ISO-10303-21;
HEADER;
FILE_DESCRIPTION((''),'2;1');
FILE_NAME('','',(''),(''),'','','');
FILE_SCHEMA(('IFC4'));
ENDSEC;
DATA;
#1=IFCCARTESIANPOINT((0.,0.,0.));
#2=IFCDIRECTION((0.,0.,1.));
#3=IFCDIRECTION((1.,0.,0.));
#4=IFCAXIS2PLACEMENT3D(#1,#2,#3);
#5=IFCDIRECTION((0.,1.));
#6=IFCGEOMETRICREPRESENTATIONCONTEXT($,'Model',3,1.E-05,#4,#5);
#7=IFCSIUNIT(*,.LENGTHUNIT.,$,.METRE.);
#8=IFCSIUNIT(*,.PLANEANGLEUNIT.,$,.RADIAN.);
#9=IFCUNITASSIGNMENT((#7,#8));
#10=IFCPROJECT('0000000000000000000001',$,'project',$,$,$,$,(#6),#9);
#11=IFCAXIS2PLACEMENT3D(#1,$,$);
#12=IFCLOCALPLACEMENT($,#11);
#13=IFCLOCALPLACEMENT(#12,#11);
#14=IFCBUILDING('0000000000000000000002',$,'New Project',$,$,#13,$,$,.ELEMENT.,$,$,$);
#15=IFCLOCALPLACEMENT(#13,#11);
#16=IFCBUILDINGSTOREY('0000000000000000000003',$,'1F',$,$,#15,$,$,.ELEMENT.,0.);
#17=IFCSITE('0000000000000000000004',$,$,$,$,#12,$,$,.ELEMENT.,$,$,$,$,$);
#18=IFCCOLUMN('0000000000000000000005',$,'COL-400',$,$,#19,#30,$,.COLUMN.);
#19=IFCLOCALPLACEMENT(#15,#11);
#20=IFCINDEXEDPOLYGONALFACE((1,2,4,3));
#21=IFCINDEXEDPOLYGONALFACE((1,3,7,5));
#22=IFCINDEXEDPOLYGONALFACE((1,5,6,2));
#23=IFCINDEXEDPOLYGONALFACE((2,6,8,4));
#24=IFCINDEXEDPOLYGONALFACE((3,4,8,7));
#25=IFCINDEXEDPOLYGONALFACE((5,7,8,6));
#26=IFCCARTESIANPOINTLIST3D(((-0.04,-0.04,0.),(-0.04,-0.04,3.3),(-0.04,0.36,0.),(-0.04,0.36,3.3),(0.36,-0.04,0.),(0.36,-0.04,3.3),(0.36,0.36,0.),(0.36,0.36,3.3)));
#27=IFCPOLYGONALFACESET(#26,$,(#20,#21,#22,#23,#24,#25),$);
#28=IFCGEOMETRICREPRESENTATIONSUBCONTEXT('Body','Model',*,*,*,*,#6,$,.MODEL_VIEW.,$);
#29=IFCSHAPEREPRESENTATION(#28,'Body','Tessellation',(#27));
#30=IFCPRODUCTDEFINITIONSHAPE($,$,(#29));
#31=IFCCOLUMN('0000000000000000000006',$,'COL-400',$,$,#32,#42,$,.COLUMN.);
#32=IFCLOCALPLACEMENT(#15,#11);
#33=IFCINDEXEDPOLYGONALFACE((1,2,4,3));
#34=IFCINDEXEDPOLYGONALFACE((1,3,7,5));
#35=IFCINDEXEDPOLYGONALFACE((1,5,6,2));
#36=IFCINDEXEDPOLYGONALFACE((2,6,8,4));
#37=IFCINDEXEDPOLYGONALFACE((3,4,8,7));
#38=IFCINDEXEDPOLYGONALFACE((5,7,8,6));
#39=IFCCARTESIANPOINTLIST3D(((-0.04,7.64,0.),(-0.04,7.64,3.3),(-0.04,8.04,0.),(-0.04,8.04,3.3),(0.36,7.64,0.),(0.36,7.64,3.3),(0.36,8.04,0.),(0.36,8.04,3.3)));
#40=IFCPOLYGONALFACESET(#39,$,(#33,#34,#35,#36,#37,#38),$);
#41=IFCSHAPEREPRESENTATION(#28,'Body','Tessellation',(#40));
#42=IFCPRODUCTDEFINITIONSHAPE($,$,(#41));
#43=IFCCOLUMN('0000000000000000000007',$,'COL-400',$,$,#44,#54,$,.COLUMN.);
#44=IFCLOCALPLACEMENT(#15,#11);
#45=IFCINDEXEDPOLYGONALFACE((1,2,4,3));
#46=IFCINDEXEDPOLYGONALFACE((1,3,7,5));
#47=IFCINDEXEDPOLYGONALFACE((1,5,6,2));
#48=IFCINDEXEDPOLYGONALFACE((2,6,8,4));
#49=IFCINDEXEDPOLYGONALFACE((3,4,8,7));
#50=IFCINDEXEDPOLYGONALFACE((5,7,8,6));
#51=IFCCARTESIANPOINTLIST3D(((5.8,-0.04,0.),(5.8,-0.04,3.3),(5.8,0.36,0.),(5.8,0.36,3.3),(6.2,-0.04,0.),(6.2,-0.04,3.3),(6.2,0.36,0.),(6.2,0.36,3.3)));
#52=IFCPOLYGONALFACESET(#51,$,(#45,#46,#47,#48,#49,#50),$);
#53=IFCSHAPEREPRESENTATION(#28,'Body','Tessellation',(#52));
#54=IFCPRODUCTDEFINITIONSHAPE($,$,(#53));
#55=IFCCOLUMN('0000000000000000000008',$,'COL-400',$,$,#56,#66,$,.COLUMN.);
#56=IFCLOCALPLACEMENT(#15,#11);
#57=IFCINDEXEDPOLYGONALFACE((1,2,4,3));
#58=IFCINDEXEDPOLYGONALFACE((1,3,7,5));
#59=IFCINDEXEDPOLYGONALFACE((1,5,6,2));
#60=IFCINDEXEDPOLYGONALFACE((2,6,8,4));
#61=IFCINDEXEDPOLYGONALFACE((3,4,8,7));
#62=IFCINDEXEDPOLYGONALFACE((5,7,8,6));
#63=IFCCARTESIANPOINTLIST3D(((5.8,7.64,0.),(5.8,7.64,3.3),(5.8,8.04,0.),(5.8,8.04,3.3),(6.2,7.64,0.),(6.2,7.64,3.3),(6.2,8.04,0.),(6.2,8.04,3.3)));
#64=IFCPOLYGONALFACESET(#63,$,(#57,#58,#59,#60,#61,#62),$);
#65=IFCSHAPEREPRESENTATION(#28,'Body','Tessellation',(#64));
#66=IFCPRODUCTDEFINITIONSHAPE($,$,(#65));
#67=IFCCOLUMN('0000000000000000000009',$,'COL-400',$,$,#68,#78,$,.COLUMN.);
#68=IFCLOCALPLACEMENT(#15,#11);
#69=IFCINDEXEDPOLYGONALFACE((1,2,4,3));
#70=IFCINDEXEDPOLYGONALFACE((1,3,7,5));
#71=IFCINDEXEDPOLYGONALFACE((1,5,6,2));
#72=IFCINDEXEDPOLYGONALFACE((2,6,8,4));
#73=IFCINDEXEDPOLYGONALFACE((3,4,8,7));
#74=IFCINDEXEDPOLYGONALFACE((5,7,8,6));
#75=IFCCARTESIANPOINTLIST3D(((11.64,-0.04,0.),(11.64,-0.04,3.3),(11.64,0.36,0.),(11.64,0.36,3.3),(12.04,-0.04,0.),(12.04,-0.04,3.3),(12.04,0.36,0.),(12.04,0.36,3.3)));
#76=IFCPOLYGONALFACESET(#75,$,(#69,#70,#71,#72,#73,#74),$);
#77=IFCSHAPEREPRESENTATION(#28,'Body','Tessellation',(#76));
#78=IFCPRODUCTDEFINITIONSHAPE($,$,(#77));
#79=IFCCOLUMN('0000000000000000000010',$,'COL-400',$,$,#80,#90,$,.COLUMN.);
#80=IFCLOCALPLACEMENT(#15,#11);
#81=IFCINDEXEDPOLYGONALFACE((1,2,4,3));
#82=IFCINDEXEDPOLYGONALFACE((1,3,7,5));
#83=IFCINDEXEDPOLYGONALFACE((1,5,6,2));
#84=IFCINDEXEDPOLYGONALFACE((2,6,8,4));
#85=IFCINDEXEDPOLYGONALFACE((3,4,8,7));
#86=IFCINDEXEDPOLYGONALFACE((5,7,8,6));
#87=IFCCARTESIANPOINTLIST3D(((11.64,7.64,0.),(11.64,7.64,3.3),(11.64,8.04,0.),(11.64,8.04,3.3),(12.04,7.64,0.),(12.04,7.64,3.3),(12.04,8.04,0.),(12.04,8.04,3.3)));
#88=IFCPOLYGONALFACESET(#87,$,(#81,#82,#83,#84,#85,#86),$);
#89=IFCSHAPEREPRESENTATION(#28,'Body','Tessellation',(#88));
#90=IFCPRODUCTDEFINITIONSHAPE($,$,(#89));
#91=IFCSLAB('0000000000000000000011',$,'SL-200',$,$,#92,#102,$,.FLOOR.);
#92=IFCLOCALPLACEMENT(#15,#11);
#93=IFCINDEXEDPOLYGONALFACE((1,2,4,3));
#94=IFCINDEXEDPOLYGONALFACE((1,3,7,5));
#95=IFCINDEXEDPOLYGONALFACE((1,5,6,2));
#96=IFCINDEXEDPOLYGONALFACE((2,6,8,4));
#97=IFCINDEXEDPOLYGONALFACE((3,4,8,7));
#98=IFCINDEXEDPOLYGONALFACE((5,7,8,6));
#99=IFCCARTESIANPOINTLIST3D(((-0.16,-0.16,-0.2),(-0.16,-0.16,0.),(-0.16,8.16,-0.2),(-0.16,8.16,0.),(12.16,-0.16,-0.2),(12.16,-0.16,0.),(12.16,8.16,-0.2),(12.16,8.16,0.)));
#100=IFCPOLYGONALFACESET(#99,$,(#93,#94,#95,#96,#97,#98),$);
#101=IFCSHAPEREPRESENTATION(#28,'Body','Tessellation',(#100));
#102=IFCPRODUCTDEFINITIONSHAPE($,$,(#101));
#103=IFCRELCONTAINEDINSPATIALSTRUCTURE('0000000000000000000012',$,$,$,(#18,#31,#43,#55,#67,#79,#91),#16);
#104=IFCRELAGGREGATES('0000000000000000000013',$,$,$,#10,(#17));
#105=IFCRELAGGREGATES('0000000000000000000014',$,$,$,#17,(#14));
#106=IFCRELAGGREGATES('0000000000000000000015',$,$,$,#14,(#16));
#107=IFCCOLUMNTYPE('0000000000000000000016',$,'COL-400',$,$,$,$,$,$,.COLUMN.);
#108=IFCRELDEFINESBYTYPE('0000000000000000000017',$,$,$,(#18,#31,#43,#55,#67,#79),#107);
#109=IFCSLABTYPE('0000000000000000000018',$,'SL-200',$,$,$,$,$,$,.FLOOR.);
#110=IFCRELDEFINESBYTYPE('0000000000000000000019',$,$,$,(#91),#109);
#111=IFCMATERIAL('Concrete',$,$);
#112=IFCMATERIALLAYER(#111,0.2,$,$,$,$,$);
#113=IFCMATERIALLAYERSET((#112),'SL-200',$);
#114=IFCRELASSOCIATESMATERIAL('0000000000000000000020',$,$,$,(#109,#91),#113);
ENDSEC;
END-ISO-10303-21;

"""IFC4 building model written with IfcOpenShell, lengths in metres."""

from ifc_helpers import new_model, si_unit, direction, frame, origin, origin_with_axes, origin_2d, place, context, subcontext, project, spatial, polyline, rectangle, outline, extrude, material, layer, layer_set, layer_usage, type_object, element, save


model = new_model("IFC4")

# Units and contexts
model_context = context("Model", 3, precision=1e-05, world=origin_with_axes(), true_north=direction((0.0, 1.0)))
body_context = subcontext(model_context, "Body", "Model", "MODEL_VIEW")
ifc_project = project(units=[si_unit("LENGTHUNIT", "METRE"), si_unit("PLANEANGLEUNIT", "RADIAN")], contexts=[model_context])

# Site, building, storey
site_placement = place(None, origin())
site = spatial("IfcSite", under=ifc_project, at=site_placement, CompositionType="ELEMENT")
building_placement = place(site_placement, origin())
building = spatial("IfcBuilding", under=site, at=building_placement, Name="New Project", CompositionType="ELEMENT")
storey_placement = place(building_placement, origin())
storey = spatial("IfcBuildingStorey", under=building, at=storey_placement, Name="1F", CompositionType="ELEMENT", Elevation=0.0)

# Columns
column_type = type_object("IfcColumnType", Name="COL-400", PredefinedType="COLUMN")
column_1_placement = place(storey_placement, origin())
element("IfcColumn", 1, at=column_1_placement, inside=storey, type_object=column_type, Name="COL-400", PredefinedType="COLUMN", context=body_context, shape_type="SweptSolid", body=[
    extrude(rectangle(XDim=0.4, YDim=0.4, at=origin_2d()), frame((0.16, 0.16, 0.0)), (0.0, 0.0, 1.0), 3.3),
])
column_2_placement = place(storey_placement, origin())
element("IfcColumn", 2, at=column_2_placement, inside=storey, type_object=column_type, Name="COL-400", PredefinedType="COLUMN", context=body_context, shape_type="SweptSolid", body=[
    extrude(rectangle(XDim=0.4, YDim=0.4, at=origin_2d()), frame((0.16, 7.84, 0.0)), (0.0, 0.0, 1.0), 3.3),
])
column_3_placement = place(storey_placement, origin())
element("IfcColumn", 3, at=column_3_placement, inside=storey, type_object=column_type, Name="COL-400", PredefinedType="COLUMN", context=body_context, shape_type="SweptSolid", body=[
    extrude(rectangle(XDim=0.4, YDim=0.4, at=origin_2d()), frame((6.0, 0.16, 0.0)), (0.0, 0.0, 1.0), 3.3),
])
column_4_placement = place(storey_placement, origin())
element("IfcColumn", 4, at=column_4_placement, inside=storey, type_object=column_type, Name="COL-400", PredefinedType="COLUMN", context=body_context, shape_type="SweptSolid", body=[
    extrude(rectangle(XDim=0.4, YDim=0.4, at=origin_2d()), frame((6.0, 7.84, 0.0)), (0.0, 0.0, 1.0), 3.3),
])
column_5_placement = place(storey_placement, origin())
element("IfcColumn", 5, at=column_5_placement, inside=storey, type_object=column_type, Name="COL-400", PredefinedType="COLUMN", context=body_context, shape_type="SweptSolid", body=[
    extrude(rectangle(XDim=0.4, YDim=0.4, at=origin_2d()), frame((11.84, 0.16, 0.0)), (0.0, 0.0, 1.0), 3.3),
])
column_6_placement = place(storey_placement, origin())
element("IfcColumn", 6, at=column_6_placement, inside=storey, type_object=column_type, Name="COL-400", PredefinedType="COLUMN", context=body_context, shape_type="SweptSolid", body=[
    extrude(rectangle(XDim=0.4, YDim=0.4, at=origin_2d()), frame((11.84, 7.84, 0.0)), (0.0, 0.0, 1.0), 3.3),
])

# Slab
ifc_material_1 = material(Name="Concrete")
ifc_layer_1 = layer(ifc_material_1, 0.2)
ifc_layer_set_1 = layer_set([ifc_layer_1], Name="SL-200")
ifc_layer_usage_1 = layer_usage(ifc_layer_set_1, "AXIS3", "NEGATIVE", 0.2)
slab_type = type_object("IfcSlabType", Name="SL-200", PredefinedType="FLOOR", material=ifc_layer_set_1)
slab_placement = place(storey_placement, frame((0.0, 0.0, -0.2)))
element("IfcSlab", 7, at=slab_placement, inside=storey, type_object=slab_type, material=ifc_layer_usage_1, Name="SL-200", PredefinedType="FLOOR", context=body_context, shape_type="SweptSolid", body=[
    extrude(outline(polyline([(-0.16, -0.16), (12.16, -0.16), (12.16, 8.16), (-0.16, 8.16), (-0.16, -0.16)])), origin(), (0.0, 0.0, 1.0), 0.2),
])

save(model, "model.ifc")
